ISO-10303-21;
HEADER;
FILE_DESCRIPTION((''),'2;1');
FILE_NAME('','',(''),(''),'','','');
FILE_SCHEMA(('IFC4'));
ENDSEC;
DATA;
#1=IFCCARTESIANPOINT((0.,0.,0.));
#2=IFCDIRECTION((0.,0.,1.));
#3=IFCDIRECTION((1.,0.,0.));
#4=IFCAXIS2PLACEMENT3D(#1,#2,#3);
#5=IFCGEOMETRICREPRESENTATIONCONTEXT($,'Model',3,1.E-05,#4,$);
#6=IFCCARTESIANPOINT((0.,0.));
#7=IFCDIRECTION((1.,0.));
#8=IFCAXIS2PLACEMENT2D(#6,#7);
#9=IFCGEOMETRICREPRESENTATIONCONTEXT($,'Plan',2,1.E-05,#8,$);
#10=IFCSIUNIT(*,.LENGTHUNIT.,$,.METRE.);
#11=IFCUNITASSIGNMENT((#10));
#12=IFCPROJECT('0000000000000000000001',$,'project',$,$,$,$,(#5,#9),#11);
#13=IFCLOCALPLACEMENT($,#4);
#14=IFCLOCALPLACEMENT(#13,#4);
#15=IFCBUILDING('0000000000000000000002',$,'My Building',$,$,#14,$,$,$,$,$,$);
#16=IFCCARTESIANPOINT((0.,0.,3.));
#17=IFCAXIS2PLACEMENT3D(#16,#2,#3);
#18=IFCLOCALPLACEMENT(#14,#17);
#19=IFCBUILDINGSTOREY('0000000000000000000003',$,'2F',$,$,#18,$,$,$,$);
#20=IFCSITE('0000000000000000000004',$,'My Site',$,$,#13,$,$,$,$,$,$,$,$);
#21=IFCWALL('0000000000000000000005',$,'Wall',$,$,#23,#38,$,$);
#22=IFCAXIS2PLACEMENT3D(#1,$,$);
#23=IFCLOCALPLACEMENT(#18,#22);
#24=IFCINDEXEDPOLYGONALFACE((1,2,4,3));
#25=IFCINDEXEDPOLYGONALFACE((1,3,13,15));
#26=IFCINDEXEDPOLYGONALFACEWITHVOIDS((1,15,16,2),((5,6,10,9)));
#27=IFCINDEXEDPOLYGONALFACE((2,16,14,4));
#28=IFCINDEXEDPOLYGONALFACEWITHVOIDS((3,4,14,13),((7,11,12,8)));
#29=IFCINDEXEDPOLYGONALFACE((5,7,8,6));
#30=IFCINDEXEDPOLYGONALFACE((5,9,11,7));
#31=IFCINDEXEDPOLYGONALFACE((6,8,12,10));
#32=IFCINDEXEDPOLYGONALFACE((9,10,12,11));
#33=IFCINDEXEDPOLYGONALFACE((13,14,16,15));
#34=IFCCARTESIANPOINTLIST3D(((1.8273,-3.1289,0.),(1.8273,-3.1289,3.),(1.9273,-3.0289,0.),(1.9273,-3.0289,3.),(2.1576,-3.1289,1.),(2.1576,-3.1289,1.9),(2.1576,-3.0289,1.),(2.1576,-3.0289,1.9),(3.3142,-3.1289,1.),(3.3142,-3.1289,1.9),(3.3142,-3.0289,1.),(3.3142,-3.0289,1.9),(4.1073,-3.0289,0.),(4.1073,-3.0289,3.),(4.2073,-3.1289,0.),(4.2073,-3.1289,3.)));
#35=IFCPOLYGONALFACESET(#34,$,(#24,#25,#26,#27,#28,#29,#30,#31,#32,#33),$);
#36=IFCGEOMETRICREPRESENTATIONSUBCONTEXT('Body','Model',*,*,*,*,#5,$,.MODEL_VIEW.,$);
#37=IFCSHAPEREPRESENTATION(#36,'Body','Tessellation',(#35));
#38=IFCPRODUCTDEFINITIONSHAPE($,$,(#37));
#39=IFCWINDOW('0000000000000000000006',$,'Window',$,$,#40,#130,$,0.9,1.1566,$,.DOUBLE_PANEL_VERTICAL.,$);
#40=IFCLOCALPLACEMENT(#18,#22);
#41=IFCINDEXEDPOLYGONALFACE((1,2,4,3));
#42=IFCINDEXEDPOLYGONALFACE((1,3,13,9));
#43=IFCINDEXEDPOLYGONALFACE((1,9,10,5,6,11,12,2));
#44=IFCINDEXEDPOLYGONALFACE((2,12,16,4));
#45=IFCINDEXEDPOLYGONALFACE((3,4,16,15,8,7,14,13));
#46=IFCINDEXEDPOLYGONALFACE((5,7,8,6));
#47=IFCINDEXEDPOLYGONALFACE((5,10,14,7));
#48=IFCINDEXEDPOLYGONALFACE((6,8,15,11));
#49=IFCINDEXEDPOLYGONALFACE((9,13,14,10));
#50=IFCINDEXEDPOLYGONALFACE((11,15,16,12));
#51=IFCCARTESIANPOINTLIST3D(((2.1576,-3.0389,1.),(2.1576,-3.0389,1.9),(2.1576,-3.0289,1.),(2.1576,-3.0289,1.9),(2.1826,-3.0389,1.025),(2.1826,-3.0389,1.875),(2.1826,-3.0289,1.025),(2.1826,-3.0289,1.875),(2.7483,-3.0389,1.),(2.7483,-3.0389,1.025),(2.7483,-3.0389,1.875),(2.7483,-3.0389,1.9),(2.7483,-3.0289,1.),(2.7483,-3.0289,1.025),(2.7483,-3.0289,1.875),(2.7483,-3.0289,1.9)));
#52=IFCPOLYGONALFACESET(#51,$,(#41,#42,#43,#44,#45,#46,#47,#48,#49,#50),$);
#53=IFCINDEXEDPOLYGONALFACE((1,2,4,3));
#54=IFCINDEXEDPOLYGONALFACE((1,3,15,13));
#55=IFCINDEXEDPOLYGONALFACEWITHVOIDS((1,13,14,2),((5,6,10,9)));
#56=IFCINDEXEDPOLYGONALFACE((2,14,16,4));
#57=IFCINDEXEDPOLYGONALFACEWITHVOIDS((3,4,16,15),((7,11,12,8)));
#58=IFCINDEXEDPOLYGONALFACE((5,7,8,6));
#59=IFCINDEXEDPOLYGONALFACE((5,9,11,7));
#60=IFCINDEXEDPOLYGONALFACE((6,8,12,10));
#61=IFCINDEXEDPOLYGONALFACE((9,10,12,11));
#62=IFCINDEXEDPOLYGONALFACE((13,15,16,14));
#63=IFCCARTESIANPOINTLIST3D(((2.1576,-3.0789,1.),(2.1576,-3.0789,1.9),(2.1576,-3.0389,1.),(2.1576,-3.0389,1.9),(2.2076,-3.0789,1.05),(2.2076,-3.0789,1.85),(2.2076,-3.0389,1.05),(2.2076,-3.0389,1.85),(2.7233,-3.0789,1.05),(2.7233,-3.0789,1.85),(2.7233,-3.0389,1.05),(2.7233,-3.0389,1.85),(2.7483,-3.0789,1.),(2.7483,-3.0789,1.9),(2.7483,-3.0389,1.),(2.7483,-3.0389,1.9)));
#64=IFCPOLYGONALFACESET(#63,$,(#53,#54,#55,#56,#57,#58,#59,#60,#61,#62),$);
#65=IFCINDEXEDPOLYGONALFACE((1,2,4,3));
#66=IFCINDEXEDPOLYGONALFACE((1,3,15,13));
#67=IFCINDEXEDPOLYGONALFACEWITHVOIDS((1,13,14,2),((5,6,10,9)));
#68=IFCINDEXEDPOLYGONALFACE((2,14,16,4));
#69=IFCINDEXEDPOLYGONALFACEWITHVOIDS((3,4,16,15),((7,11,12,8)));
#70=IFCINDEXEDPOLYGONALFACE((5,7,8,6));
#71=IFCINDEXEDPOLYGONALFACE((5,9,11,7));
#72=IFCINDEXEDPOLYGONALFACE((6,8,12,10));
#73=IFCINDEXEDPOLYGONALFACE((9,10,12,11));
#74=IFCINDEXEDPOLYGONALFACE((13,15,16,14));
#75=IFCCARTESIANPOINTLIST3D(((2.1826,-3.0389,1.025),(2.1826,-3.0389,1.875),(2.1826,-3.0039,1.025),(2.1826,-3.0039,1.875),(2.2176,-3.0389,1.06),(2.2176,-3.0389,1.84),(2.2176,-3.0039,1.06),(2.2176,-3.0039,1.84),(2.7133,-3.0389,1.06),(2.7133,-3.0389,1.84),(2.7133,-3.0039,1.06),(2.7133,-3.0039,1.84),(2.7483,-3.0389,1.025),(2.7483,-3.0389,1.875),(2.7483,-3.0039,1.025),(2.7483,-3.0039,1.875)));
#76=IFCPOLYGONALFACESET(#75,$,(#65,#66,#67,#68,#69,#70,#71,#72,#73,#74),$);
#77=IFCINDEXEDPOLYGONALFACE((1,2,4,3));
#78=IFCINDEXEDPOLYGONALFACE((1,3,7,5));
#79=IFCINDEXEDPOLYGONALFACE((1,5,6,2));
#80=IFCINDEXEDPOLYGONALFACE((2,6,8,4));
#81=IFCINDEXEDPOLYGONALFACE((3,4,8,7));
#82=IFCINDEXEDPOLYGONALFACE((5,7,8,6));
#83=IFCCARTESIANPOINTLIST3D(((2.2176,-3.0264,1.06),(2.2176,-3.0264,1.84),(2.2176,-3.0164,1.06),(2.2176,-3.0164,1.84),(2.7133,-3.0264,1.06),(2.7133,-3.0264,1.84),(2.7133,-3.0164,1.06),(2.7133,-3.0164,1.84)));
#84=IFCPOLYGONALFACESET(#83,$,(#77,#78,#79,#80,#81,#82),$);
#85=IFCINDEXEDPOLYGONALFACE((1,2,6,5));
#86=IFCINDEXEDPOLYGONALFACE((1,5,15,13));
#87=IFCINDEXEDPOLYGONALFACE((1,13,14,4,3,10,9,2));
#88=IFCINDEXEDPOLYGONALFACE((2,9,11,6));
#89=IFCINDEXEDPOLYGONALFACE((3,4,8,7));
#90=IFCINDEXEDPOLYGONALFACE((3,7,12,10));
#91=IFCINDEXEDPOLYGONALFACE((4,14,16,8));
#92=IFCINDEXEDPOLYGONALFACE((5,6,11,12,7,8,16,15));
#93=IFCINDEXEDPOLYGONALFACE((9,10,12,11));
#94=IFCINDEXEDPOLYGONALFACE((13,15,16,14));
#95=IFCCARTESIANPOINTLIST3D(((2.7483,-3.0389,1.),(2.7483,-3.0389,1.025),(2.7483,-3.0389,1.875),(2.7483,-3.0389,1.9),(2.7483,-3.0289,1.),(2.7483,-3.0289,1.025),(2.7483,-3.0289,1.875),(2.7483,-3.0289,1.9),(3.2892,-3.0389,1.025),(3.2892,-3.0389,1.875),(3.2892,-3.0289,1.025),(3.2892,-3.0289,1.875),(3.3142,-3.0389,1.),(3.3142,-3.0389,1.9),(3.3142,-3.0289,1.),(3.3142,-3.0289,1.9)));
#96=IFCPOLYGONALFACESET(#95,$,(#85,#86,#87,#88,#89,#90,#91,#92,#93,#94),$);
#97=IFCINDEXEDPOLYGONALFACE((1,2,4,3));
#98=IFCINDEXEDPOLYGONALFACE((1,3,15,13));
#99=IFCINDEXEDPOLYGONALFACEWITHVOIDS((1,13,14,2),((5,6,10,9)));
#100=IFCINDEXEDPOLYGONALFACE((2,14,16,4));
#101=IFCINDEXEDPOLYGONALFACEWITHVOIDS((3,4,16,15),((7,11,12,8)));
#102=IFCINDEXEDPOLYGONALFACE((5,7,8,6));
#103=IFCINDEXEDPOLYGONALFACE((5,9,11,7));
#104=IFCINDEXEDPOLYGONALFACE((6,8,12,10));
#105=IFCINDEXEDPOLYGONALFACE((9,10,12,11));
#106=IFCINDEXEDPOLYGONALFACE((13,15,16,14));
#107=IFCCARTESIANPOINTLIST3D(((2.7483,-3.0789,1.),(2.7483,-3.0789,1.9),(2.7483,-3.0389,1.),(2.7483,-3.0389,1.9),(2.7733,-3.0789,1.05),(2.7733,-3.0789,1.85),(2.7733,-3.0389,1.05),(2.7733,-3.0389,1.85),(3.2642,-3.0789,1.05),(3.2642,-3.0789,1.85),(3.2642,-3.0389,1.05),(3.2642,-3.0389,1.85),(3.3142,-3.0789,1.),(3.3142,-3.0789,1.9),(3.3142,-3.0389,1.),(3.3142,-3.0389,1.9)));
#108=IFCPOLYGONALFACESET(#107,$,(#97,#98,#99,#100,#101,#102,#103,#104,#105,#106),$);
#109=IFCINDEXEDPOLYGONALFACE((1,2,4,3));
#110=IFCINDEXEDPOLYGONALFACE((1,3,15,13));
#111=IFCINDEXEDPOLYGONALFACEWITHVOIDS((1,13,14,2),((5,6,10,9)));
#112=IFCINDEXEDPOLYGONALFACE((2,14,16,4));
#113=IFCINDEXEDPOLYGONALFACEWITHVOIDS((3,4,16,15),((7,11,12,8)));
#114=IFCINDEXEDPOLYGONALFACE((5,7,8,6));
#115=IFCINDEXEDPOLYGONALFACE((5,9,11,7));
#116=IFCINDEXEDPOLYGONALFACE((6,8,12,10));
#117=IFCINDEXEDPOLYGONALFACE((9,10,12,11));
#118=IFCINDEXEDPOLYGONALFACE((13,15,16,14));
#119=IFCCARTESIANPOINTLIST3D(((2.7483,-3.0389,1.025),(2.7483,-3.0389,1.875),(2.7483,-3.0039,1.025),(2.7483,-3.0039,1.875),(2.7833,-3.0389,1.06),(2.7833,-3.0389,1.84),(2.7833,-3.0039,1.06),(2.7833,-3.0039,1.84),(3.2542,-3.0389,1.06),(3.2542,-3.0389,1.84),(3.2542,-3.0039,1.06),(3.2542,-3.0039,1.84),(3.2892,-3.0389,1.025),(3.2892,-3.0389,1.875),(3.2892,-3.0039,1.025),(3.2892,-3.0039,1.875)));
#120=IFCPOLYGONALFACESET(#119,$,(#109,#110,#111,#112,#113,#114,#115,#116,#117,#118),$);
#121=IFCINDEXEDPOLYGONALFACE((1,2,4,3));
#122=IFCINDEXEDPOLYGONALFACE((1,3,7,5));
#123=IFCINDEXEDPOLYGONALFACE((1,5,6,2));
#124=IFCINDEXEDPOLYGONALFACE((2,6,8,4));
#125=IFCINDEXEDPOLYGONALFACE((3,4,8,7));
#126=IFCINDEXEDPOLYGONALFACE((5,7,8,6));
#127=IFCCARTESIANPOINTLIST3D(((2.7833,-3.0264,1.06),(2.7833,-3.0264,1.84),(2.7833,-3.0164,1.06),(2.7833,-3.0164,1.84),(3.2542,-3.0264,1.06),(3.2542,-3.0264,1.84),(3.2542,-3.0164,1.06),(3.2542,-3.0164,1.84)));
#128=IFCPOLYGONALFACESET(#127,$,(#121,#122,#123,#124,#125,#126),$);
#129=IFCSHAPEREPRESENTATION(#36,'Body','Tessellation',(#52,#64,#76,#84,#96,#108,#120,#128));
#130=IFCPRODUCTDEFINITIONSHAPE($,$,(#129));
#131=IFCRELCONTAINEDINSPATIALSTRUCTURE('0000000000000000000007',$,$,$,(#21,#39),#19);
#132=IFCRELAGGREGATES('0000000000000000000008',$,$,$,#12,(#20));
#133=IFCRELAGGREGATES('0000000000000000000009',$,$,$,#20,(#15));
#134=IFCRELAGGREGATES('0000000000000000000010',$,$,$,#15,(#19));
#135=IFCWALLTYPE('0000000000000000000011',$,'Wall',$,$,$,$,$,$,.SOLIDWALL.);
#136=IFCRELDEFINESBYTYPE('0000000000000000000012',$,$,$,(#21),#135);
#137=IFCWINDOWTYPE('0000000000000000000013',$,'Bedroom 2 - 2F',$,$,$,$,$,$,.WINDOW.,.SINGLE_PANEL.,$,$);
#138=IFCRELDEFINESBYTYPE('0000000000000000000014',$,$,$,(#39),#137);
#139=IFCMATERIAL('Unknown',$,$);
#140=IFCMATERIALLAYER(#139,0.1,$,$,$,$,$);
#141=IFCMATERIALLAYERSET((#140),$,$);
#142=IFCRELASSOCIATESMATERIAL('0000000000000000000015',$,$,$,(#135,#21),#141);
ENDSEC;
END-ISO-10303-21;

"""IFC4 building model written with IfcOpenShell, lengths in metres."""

from ifc_helpers import new_model, entity, si_unit, frame, origin_with_axes, origin_2d_with_axis, place, context, subcontext, project, spatial, line, indexed_curve, outline, extrude, shape, source, transform, mapped, material, layer, layer_set, layer_usage, type_object, type_shapes, element, fill, save


model = new_model("IFC4")

# Units and contexts
model_context = context("Model", 3, precision=1e-05, world=origin_with_axes())
plan_context = context("Plan", 2, precision=1e-05, world=origin_2d_with_axis())
body_context_1 = subcontext(model_context, "Body", "Model", "MODEL_VIEW")
body_context_2 = subcontext(plan_context, "Body", "Plan", "PLAN_VIEW")
ifc_project = project(units=[si_unit("LENGTHUNIT", "METRE")], contexts=[model_context, plan_context])

# Site, building, storey
site_placement = place(None, origin_with_axes())
site = spatial("IfcSite", under=ifc_project, at=site_placement, Name="My Site")
building_placement = place(site_placement, origin_with_axes())
building = spatial("IfcBuilding", under=site, at=building_placement, Name="My Building")
storey_placement = place(building_placement, frame((0.0, 0.0, 3.0), z_axis=(0.0, 0.0, 1.0), x_axis=(1.0, 0.0, 0.0)))
storey = spatial("IfcBuildingStorey", under=building, at=storey_placement, Name="2F")

# Shared definitions
ifc_material = material(Name="Unknown")
ifc_layer = layer(ifc_material, 0.1)
ifc_layer_set = layer_set([ifc_layer])
wall_type = type_object("IfcWallType", Name="Wall", PredefinedType="SOLIDWALL", material=ifc_layer_set)

# Wall, opening, window
ifc_layer_usage_1 = layer_usage(ifc_layer_set, "AXIS2", "POSITIVE", 0.0)
wall_1_placement = place(storey_placement, frame((1.8273, -3.1289, 0.0), z_axis=(0.0, 0.0, 1.0), x_axis=(1.0, 0.0, 0.0)))
wall_1 = element("IfcWall", 1, at=wall_1_placement, inside=storey, type_object=wall_type, material=ifc_layer_usage_1, Name="Wall", context=body_context_1, shape_type="SweptSolid", body=[
    extrude(outline(indexed_curve([(0.0, 0.0), (0.1, 0.1), (2.28, 0.1), (2.38, 0.0)], segments=[line(1, 2, 3, 4, 1)])), origin_with_axes(), (0.0, 0.0, 1.0), 3.0),
])
shared_shape_1 = source(origin_with_axes(), body_context_1, "Body", "SweptSolid", [
    extrude(outline(indexed_curve([(0.0, 0.0), (1.1566, 0.0), (1.1566, 0.9), (0.0, 0.9)], segments=[line(1, 2, 3, 4, 1)])), frame((0.0, -0.6, 0.0), z_axis=(0.0, -1.0, 0.0), x_axis=(1.0, 0.0, 0.0)), (0.0, 0.0, -1.0), 1.2),
])
opening_1_placement = place(wall_1_placement, frame((0.3303, 0.0, 1.0), z_axis=(0.0, 0.0, 1.0), x_axis=(1.0, 0.0, 0.0)))
opening_1 = element("IfcOpeningElement", 2, at=opening_1_placement, cuts=wall_1, PredefinedType="OPENING", context=body_context_1, shape_type="MappedRepresentation", body=[
    mapped(shared_shape_1, transform((0.0, 0.0, 0.0), x_axis=(1.0, 0.0, 0.0), y_axis=(0.0, 1.0, 0.0), z_axis=(0.0, 0.0, 1.0), scale=1.0)),
])
window_type_1 = type_object("IfcWindowType", Name="Bedroom 2 - 2F", PartitioningType="SINGLE_PANEL", PredefinedType="WINDOW")
shared_shape_2 = source(origin_with_axes(), body_context_1, "Body", "SweptSolid", [
    extrude(outline(indexed_curve([(0.5908, 0.0), (0.0, 0.0), (0.0, 0.9), (0.5908, 0.9), (0.5908, 0.875), (0.025, 0.875), (0.025, 0.025), (0.5908, 0.025)], segments=[line(1, 2, 3, 4, 5, 6, 7, 8, 1)])), frame((0.0, 0.09, 0.0), z_axis=(0.0, -1.0, 0.0), x_axis=(1.0, 0.0, 0.0)), (0.0, 0.0, -1.0), 0.01),
    extrude(outline(indexed_curve([(0.0, 0.0), (0.5908, 0.0), (0.5908, 0.9), (0.0, 0.9)], segments=[line(1, 2, 3, 4, 1)]), holes=[indexed_curve([(0.05, 0.05), (0.5658, 0.05), (0.5658, 0.85), (0.05, 0.85)], segments=[line(1, 2, 3, 4, 1)])]), frame((0.0, 0.05, 0.0), z_axis=(0.0, -1.0, 0.0), x_axis=(1.0, 0.0, 0.0)), (0.0, 0.0, -1.0), 0.04),
    extrude(outline(indexed_curve([(0.0, 0.0), (0.5658, 0.0), (0.5658, 0.85), (0.0, 0.85)], segments=[line(1, 2, 3, 4, 1)]), holes=[indexed_curve([(0.035, 0.035), (0.5308, 0.035), (0.5308, 0.815), (0.035, 0.815)], segments=[line(1, 2, 3, 4, 1)])]), frame((0.025, 0.09, 0.025), z_axis=(0.0, -1.0, 0.0), x_axis=(1.0, 0.0, 0.0)), (0.0, 0.0, -1.0), 0.035),
    extrude(outline(indexed_curve([(0.035, 0.035), (0.5308, 0.035), (0.5308, 0.815), (0.035, 0.815)], segments=[line(1, 2, 3, 4, 1)])), frame((0.025, 0.1025, 0.025), z_axis=(0.0, -1.0, 0.0), x_axis=(1.0, 0.0, 0.0)), (0.0, 0.0, -1.0), 0.01),
    extrude(outline(indexed_curve([(0.0, 0.9), (0.5659, 0.9), (0.5659, 0.0), (0.0, 0.0), (0.0, 0.025), (0.5409, 0.025), (0.5409, 0.875), (0.0, 0.875)], segments=[line(1, 2, 3, 4, 5, 6, 7, 8, 1)])), frame((0.5908, 0.09, 0.0), z_axis=(0.0, -1.0, 0.0), x_axis=(1.0, 0.0, 0.0)), (0.0, 0.0, -1.0), 0.01),
    extrude(outline(indexed_curve([(0.0, 0.0), (0.5659, 0.0), (0.5659, 0.9), (0.0, 0.9)], segments=[line(1, 2, 3, 4, 1)]), holes=[indexed_curve([(0.025, 0.05), (0.5159, 0.05), (0.5159, 0.85), (0.025, 0.85)], segments=[line(1, 2, 3, 4, 1)])]), frame((0.5908, 0.05, 0.0), z_axis=(0.0, -1.0, 0.0), x_axis=(1.0, 0.0, 0.0)), (0.0, 0.0, -1.0), 0.04),
    extrude(outline(indexed_curve([(0.0, 0.0), (0.5409, 0.0), (0.5409, 0.85), (0.0, 0.85)], segments=[line(1, 2, 3, 4, 1)]), holes=[indexed_curve([(0.035, 0.035), (0.5059, 0.035), (0.5059, 0.815), (0.035, 0.815)], segments=[line(1, 2, 3, 4, 1)])]), frame((0.5908, 0.09, 0.025), z_axis=(0.0, -1.0, 0.0), x_axis=(1.0, 0.0, 0.0)), (0.0, 0.0, -1.0), 0.035),
    extrude(outline(indexed_curve([(0.035, 0.035), (0.5059, 0.035), (0.5059, 0.815), (0.035, 0.815)], segments=[line(1, 2, 3, 4, 1)])), frame((0.5908, 0.1025, 0.025), z_axis=(0.0, -1.0, 0.0), x_axis=(1.0, 0.0, 0.0)), (0.0, 0.0, -1.0), 0.01),
])
shared_shape_3 = source(origin_with_axes(), body_context_2, "Body", "Curve2D", [
    entity("IfcIndexedPolyCurve", entity("IfcCartesianPointList2D", [[0.05, 0.05], [0.5658, 0.05]])),
    entity("IfcIndexedPolyCurve", entity("IfcCartesianPointList2D", [[0.0, 0.1], [0.025, 0.1], [0.025, 0.09], [0.05, 0.09], [0.05, 0.05], [0.0, 0.05]]), [entity("IfcLineIndex", [1, 2, 3, 4, 5, 6, 1])]),
    entity("IfcIndexedPolyCurve", entity("IfcCartesianPointList2D", [[0.5908, 0.1], [0.5908, 0.1], [0.5908, 0.09], [0.5658, 0.09], [0.5658, 0.05], [0.5908, 0.05]])),
    entity("IfcIndexedPolyCurve", entity("IfcCartesianPointList2D", [[0.025, 0.09], [0.06, 0.09], [0.06, 0.125], [0.025, 0.125]]), [entity("IfcLineIndex", [1, 2, 3, 4, 1])]),
    entity("IfcIndexedPolyCurve", entity("IfcCartesianPointList2D", [[0.5908, 0.09], [0.5558, 0.09], [0.5558, 0.125], [0.5908, 0.125]]), [entity("IfcLineIndex", [1, 2, 3, 4, 1])]),
    entity("IfcIndexedPolyCurve", entity("IfcCartesianPointList2D", [[0.06, 0.09], [0.5558, 0.09]])),
    entity("IfcIndexedPolyCurve", entity("IfcCartesianPointList2D", [[0.06, 0.125], [0.5558, 0.125]])),
    entity("IfcIndexedPolyCurve", entity("IfcCartesianPointList2D", [[0.06, 0.1075], [0.5558, 0.1075]])),
    entity("IfcIndexedPolyCurve", entity("IfcCartesianPointList2D", [[0.6158, 0.05], [1.1066, 0.05]])),
    entity("IfcIndexedPolyCurve", entity("IfcCartesianPointList2D", [[0.5908, 0.1], [0.5908, 0.1], [0.5908, 0.09], [0.6158, 0.09], [0.6158, 0.05], [0.5908, 0.05]])),
    entity("IfcIndexedPolyCurve", entity("IfcCartesianPointList2D", [[1.1566, 0.1], [1.1316, 0.1], [1.1316, 0.09], [1.1066, 0.09], [1.1066, 0.05], [1.1566, 0.05]]), [entity("IfcLineIndex", [1, 2, 3, 4, 5, 6, 1])]),
    entity("IfcIndexedPolyCurve", entity("IfcCartesianPointList2D", [[0.5908, 0.09], [0.6258, 0.09], [0.6258, 0.125], [0.5908, 0.125]]), [entity("IfcLineIndex", [1, 2, 3, 4, 1])]),
    entity("IfcIndexedPolyCurve", entity("IfcCartesianPointList2D", [[1.1316, 0.09], [1.0966, 0.09], [1.0966, 0.125], [1.1316, 0.125]]), [entity("IfcLineIndex", [1, 2, 3, 4, 1])]),
    entity("IfcIndexedPolyCurve", entity("IfcCartesianPointList2D", [[0.6258, 0.09], [1.0966, 0.09]])),
    entity("IfcIndexedPolyCurve", entity("IfcCartesianPointList2D", [[0.6258, 0.125], [1.0966, 0.125]])),
    entity("IfcIndexedPolyCurve", entity("IfcCartesianPointList2D", [[0.6258, 0.1075], [1.0966, 0.1075]])),
])
type_shapes(window_type_1, [shared_shape_2, shared_shape_3])
window_1_placement = place(opening_1_placement, origin_with_axes())
window_1 = element("IfcWindow", 3, at=window_1_placement, inside=storey, type_object=window_type_1, Name="Window", OverallHeight=0.9, OverallWidth=1.1566, PartitioningType="DOUBLE_PANEL_VERTICAL", shapes=[
    shape(body_context_1, "Body", "MappedRepresentation", [mapped(shared_shape_2, transform((0.0, 0.0, 0.0), x_axis=(1.0, 0.0, 0.0), y_axis=(0.0, 1.0, 0.0), z_axis=(0.0, 0.0, 1.0), scale=1.0))]),
    shape(body_context_2, "Body", "MappedRepresentation", [mapped(shared_shape_3, transform((0.0, 0.0, 0.0), x_axis=(1.0, 0.0, 0.0), y_axis=(0.0, 1.0, 0.0), z_axis=(0.0, 0.0, 1.0), scale=1.0))]),
])
fill(opening_1, window_1)

save(model, "model.ifc")
